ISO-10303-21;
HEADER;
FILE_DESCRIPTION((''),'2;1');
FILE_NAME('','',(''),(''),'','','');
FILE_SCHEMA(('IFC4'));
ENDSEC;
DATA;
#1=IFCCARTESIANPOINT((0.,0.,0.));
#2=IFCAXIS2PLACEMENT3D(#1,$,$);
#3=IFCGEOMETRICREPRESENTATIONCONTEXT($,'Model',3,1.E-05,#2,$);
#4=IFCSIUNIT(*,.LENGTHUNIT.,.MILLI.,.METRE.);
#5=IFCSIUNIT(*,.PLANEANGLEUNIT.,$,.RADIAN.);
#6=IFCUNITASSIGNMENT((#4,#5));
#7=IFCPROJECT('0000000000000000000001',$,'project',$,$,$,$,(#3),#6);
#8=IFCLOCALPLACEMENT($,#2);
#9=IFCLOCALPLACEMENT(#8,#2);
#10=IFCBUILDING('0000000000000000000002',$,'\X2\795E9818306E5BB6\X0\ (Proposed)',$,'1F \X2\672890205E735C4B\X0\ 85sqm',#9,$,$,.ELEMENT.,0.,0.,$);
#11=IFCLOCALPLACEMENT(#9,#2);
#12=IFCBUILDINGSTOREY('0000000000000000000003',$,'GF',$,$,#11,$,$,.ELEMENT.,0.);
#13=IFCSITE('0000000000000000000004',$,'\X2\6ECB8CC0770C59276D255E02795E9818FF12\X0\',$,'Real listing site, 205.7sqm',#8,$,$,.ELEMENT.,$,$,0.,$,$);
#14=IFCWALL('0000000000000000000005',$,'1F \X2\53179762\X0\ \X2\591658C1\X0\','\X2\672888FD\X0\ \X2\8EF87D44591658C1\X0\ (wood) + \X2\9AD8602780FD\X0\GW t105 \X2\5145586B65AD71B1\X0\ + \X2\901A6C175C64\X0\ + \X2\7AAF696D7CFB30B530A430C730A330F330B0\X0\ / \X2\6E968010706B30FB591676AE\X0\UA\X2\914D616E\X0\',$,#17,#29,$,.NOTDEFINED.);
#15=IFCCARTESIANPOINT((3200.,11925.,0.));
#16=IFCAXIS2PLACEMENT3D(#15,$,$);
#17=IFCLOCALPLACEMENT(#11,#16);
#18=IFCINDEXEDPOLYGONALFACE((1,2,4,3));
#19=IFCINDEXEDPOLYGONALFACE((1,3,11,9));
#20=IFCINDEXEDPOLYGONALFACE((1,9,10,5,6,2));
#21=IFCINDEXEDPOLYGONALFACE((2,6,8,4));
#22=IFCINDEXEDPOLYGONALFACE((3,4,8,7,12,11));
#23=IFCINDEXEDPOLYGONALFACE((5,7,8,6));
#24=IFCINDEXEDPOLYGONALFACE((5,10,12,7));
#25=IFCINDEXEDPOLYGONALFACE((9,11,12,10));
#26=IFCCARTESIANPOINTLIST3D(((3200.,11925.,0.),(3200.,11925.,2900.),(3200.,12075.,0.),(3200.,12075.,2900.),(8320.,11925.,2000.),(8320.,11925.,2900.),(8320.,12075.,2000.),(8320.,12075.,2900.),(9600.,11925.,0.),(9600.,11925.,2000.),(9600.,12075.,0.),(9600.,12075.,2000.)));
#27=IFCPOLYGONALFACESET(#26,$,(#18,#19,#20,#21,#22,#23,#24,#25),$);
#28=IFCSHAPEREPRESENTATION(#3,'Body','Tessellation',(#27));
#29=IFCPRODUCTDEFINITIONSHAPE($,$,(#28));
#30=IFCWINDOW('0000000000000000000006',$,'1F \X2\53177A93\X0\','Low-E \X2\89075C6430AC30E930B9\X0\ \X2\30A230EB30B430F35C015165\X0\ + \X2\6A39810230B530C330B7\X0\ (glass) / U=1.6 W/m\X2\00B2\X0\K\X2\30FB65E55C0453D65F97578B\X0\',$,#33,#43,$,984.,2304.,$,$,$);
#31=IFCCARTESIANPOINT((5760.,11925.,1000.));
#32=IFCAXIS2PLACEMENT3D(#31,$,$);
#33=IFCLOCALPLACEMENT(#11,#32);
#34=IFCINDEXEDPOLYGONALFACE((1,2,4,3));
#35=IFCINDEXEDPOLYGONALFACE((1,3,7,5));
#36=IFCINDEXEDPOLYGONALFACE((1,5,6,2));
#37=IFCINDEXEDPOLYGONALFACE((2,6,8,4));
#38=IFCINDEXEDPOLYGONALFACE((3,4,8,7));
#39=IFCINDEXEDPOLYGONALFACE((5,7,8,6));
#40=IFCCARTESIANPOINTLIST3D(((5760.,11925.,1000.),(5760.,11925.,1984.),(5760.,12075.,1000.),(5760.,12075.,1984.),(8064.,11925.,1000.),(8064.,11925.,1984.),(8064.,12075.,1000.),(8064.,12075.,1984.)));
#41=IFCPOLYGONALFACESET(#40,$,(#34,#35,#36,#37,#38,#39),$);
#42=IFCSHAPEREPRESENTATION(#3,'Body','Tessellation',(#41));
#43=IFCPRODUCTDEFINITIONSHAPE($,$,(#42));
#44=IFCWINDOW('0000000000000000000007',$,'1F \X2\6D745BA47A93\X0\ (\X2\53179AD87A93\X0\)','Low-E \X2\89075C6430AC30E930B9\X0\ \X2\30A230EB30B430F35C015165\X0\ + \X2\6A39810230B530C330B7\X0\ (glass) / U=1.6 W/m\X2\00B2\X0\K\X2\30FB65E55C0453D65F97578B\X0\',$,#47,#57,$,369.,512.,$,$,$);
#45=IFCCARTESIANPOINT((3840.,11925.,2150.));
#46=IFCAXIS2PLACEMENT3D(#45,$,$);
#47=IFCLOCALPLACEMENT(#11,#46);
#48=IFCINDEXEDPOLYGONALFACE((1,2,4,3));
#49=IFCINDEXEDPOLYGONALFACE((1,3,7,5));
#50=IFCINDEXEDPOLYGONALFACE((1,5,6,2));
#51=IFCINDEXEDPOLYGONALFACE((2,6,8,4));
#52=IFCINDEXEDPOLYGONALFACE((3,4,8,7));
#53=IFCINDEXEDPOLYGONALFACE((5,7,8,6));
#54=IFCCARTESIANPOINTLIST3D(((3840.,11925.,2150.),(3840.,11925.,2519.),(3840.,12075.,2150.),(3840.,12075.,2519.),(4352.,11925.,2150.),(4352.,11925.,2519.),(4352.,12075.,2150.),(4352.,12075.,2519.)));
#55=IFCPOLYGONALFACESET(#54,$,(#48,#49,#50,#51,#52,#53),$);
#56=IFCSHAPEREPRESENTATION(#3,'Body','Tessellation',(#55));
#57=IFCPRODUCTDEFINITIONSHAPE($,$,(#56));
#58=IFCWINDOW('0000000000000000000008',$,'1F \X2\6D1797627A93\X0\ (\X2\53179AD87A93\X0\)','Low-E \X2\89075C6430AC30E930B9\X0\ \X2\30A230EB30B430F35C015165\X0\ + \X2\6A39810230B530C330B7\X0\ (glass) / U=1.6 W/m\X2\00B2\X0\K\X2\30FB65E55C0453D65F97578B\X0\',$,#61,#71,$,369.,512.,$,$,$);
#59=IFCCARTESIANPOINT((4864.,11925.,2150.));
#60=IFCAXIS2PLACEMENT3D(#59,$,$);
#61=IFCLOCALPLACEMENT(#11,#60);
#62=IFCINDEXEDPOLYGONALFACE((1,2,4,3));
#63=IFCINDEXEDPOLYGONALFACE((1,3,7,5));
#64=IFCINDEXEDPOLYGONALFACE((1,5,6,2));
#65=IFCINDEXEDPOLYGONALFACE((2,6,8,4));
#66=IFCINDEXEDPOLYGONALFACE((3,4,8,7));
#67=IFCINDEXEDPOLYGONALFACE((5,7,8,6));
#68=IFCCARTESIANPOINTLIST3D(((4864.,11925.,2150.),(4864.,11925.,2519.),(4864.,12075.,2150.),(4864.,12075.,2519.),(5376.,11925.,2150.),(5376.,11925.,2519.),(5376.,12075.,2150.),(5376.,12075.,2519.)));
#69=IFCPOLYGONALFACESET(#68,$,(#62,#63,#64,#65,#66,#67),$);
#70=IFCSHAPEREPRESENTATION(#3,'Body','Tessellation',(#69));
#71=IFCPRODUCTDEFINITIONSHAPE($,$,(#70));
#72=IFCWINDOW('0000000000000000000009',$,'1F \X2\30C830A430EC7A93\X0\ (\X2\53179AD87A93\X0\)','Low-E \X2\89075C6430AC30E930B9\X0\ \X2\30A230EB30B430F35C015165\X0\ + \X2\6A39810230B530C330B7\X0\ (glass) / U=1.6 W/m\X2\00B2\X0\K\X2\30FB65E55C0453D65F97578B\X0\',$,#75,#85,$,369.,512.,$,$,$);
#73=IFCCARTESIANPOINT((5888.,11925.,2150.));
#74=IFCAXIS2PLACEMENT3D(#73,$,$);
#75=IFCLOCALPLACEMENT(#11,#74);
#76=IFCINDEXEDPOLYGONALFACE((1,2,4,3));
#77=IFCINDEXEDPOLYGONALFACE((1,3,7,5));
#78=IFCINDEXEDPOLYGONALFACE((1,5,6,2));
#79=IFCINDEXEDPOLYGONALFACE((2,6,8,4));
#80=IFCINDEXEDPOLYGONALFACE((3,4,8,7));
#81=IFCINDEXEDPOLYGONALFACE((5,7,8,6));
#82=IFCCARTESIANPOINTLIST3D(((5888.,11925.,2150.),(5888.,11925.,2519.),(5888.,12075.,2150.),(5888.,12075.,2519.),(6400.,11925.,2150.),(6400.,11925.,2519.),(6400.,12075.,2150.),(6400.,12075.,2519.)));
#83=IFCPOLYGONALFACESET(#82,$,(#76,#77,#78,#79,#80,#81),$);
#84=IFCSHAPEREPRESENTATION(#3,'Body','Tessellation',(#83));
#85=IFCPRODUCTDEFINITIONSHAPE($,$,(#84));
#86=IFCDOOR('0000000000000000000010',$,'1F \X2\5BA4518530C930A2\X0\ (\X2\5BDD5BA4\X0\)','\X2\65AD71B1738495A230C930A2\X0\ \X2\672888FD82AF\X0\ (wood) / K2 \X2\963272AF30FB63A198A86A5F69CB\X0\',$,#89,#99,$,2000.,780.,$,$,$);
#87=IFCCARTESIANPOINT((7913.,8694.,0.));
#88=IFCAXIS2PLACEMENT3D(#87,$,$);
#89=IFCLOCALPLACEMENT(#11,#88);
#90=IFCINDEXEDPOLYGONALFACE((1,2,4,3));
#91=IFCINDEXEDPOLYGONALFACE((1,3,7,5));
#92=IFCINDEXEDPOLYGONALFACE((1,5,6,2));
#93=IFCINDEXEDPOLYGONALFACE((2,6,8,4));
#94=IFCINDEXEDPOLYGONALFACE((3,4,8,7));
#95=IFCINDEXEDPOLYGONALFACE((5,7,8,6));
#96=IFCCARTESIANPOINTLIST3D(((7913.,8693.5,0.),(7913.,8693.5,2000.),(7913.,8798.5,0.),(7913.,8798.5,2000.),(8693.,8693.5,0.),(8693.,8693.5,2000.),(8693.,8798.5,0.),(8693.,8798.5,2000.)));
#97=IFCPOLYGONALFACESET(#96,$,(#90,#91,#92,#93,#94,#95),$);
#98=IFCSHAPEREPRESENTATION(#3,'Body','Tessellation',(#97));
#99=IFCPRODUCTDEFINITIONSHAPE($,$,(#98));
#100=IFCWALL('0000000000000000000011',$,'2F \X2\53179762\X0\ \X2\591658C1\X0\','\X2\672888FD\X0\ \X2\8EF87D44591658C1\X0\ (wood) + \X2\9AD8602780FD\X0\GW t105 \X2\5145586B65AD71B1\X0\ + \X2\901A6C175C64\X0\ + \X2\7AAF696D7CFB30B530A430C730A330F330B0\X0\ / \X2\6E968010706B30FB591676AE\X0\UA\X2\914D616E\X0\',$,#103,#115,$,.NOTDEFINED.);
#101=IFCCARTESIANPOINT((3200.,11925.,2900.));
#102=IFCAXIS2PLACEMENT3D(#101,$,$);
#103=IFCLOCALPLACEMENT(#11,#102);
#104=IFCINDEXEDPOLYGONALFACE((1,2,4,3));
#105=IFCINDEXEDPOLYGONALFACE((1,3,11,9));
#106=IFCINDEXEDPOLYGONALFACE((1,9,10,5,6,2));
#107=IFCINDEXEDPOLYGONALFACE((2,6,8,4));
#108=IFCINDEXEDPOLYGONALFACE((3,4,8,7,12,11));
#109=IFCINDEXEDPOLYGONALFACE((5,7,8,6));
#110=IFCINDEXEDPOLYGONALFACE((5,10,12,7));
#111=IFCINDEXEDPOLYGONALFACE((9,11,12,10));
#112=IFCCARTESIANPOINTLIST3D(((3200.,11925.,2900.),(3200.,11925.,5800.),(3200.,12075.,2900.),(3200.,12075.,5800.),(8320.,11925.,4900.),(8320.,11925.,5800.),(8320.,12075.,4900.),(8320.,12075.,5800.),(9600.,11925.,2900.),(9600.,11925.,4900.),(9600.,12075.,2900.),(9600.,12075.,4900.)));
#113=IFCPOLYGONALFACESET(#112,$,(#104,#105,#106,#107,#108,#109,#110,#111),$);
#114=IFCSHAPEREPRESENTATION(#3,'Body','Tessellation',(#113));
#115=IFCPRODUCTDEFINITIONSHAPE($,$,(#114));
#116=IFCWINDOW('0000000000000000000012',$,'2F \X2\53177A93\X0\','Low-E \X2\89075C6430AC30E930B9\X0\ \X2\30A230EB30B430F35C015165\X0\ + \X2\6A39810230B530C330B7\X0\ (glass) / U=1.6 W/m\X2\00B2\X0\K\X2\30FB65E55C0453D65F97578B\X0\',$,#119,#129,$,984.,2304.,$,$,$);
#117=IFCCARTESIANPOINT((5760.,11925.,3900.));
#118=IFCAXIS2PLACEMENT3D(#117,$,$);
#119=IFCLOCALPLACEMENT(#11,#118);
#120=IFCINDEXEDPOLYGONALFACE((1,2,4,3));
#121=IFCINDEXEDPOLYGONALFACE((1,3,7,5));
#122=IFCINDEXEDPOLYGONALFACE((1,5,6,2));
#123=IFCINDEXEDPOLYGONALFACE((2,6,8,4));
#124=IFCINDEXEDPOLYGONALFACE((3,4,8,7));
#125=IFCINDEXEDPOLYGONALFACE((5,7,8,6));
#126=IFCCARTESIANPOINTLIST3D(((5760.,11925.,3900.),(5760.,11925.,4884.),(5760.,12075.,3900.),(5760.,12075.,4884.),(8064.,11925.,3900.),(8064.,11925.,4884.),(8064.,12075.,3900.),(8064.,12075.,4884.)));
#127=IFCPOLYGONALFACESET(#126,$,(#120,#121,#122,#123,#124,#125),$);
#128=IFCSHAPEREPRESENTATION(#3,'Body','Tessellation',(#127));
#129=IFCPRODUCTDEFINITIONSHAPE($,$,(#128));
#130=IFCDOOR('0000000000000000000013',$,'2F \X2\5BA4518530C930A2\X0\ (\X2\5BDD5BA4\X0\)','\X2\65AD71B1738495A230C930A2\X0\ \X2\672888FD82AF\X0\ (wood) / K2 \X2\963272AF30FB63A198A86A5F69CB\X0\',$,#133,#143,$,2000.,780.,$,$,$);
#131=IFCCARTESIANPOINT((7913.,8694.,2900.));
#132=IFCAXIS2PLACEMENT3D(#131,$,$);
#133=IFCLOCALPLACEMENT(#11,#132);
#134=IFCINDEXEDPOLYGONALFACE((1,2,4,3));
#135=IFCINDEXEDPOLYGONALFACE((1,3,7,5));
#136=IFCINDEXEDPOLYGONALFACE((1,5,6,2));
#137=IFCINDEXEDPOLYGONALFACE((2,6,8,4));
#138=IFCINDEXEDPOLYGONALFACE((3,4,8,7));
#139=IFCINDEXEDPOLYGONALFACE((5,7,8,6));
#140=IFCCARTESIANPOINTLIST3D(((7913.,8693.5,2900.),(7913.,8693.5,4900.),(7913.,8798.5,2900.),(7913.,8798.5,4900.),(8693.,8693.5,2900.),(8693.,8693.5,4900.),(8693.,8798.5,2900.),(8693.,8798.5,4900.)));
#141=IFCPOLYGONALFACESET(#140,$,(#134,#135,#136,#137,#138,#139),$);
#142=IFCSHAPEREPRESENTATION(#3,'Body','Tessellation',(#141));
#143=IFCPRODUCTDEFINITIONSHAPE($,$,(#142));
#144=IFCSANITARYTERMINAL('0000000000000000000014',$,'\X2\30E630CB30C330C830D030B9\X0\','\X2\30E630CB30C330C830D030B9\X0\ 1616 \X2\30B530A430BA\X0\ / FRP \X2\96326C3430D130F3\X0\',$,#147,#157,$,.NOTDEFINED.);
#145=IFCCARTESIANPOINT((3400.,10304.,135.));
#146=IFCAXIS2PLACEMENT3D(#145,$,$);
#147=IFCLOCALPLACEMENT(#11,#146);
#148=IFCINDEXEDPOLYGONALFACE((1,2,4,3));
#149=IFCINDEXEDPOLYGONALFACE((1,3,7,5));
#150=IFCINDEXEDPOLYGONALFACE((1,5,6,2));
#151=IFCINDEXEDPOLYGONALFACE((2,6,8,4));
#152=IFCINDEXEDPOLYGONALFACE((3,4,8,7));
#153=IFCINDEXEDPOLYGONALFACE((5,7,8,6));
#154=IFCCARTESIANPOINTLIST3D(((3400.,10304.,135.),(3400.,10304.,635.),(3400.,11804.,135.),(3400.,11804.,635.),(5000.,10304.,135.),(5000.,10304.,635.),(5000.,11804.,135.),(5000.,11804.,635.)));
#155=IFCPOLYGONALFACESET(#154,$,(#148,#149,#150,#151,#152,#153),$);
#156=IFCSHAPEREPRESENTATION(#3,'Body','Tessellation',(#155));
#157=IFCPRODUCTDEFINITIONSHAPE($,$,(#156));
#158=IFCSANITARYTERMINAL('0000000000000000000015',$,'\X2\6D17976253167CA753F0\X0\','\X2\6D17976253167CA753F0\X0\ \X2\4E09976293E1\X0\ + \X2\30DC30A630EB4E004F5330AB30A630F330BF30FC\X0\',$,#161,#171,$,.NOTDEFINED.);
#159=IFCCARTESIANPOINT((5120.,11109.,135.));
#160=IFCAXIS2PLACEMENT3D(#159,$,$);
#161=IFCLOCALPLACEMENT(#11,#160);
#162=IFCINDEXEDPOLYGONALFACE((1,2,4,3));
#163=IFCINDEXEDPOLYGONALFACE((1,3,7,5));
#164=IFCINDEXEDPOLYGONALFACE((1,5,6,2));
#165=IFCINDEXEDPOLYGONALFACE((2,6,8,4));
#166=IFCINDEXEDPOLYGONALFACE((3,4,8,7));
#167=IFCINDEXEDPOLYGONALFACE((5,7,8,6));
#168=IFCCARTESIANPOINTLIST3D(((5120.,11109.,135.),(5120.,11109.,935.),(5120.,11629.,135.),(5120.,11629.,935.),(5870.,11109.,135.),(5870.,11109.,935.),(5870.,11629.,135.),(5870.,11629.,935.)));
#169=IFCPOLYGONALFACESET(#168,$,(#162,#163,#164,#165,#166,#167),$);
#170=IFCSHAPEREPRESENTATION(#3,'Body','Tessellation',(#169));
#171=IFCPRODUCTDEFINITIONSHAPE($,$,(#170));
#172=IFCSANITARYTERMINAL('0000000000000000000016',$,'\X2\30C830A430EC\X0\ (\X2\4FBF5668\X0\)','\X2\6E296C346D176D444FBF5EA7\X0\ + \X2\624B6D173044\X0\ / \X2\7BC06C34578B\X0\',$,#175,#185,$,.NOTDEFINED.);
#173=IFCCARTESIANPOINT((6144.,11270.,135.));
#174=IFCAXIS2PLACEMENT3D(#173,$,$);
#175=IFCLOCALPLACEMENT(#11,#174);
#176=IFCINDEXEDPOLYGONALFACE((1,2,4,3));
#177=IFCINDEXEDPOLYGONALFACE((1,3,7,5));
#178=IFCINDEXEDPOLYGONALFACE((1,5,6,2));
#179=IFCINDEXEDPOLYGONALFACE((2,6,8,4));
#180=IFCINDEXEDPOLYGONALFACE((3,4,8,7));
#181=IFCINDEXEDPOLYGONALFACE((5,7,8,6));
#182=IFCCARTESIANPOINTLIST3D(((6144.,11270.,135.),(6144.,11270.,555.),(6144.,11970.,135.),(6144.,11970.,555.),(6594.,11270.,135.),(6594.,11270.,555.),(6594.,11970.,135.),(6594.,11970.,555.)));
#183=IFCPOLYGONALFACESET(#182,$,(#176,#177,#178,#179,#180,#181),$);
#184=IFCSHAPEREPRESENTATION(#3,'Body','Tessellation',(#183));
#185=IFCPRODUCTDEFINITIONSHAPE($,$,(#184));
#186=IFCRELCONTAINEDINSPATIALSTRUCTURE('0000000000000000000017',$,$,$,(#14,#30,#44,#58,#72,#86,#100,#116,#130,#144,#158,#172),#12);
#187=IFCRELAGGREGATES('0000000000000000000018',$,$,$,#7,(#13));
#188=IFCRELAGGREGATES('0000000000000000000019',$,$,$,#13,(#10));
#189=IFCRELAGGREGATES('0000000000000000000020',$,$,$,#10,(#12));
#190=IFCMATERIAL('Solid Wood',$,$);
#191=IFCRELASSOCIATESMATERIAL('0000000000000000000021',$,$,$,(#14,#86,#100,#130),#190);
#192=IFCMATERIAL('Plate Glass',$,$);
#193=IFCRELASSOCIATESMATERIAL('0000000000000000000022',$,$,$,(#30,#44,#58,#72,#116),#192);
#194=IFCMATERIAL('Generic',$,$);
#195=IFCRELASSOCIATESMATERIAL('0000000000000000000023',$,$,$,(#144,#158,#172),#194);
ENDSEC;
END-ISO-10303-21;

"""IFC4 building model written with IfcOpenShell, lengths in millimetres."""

from ifc_helpers import new_model, si_unit, frame, frame_2d, origin, place, context, project, spatial, rectangle, extrude, material, element, fill, save


model = new_model("IFC4")

# Units and contexts
model_context = context("Model", 3, precision=1e-05, world=origin())
ifc_project = project(units=[si_unit("LENGTHUNIT", "METRE", prefix="MILLI"), si_unit("PLANEANGLEUNIT", "RADIAN")], contexts=[model_context])

# Site, building, storey
site_placement = place(None, origin())
site = spatial("IfcSite", under=ifc_project, at=site_placement, Name="滋賀県大津市神領２", ObjectType="Real listing site, 205.7sqm", CompositionType="ELEMENT", RefElevation=0.0)
building_placement = place(site_placement, origin())
building = spatial("IfcBuilding", under=site, at=building_placement, Name="神領の家 (Proposed)", ObjectType="1F 木造平屋 85sqm", CompositionType="ELEMENT", ElevationOfRefHeight=0.0, ElevationOfTerrain=0.0)
storey_placement = place(building_placement, origin())
storey = spatial("IfcBuildingStorey", under=building, at=storey_placement, Name="GF", CompositionType="ELEMENT", Elevation=0.0)

# Wall, openings, windows
ifc_material_1 = material(Name="Solid Wood")
wall_1_placement = place(storey_placement, frame((3200.0, 11925.0, 0.0)))
wall_1 = element("IfcWall", 1, at=wall_1_placement, inside=storey, material=ifc_material_1, Name="1F 北面 外壁", Description="木製 軸組外壁 (wood) + 高性能GW t105 充填断熱 + 通気層 + 窯業系サイディング / 準耐火・外皮UA配慮", PredefinedType="NOTDEFINED", context=model_context, shape_type="SweptSolid", body=[
    extrude(rectangle(XDim=6400.0, YDim=150.0, at=frame_2d((3200.0, 75.0))), frame((3200.0, 11925.0, 0.0)), (0.0, 0.0, 1.0), 2900.0),
])
opening_1_placement = place(storey_placement, frame((5760.0, 11925.0, 1000.0)))
opening_1 = element("IfcOpeningElement", 2, at=opening_1_placement, cuts=wall_1, PredefinedType="NOTDEFINED", context=model_context, shape_type="SweptSolid", body=[
    extrude(rectangle(XDim=2304.0, YDim=150.0, at=frame_2d((1152.0, 75.0))), frame((5760.0, 11925.0, 1000.0)), (0.0, 0.0, 1.0), 984.0),
])
opening_2_placement = place(storey_placement, frame((3840.0, 11925.0, 2150.0)))
opening_2 = element("IfcOpeningElement", 3, at=opening_2_placement, cuts=wall_1, PredefinedType="NOTDEFINED", context=model_context, shape_type="SweptSolid", body=[
    extrude(rectangle(XDim=512.0, YDim=150.0, at=frame_2d((256.0, 75.0))), frame((3840.0, 11925.0, 2150.0)), (0.0, 0.0, 1.0), 369.0),
])
opening_3_placement = place(storey_placement, frame((4864.0, 11925.0, 2150.0)))
opening_3 = element("IfcOpeningElement", 4, at=opening_3_placement, cuts=wall_1, PredefinedType="NOTDEFINED", context=model_context, shape_type="SweptSolid", body=[
    extrude(rectangle(XDim=512.0, YDim=150.0, at=frame_2d((256.0, 75.0))), frame((4864.0, 11925.0, 2150.0)), (0.0, 0.0, 1.0), 369.0),
])
opening_4_placement = place(storey_placement, frame((5888.0, 11925.0, 2150.0)))
opening_4 = element("IfcOpeningElement", 5, at=opening_4_placement, cuts=wall_1, PredefinedType="NOTDEFINED", context=model_context, shape_type="SweptSolid", body=[
    extrude(rectangle(XDim=512.0, YDim=150.0, at=frame_2d((256.0, 75.0))), frame((5888.0, 11925.0, 2150.0)), (0.0, 0.0, 1.0), 369.0),
])
ifc_material_2 = material(Name="Plate Glass")
window_1_placement = place(storey_placement, frame((5760.0, 11925.0, 1000.0)))
window_1 = element("IfcWindow", 6, at=window_1_placement, inside=storey, material=ifc_material_2, Name="1F 北窓", Description="Low-E 複層ガラス アルゴン封入 + 樹脂サッシ (glass) / U=1.6 W/m²K・日射取得型", OverallHeight=984.0, OverallWidth=2304.0, context=model_context, shape_type="SweptSolid", body=[
    extrude(rectangle(XDim=2304.0, YDim=150.0, at=frame_2d((1152.0, 75.0))), frame((5760.0, 11925.0, 1000.0)), (0.0, 0.0, 1.0), 984.0),
])
fill(opening_1, window_1)
window_2_placement = place(storey_placement, frame((3840.0, 11925.0, 2150.0)))
window_2 = element("IfcWindow", 7, at=window_2_placement, inside=storey, material=ifc_material_2, Name="1F 浴室窓 (北高窓)", Description="Low-E 複層ガラス アルゴン封入 + 樹脂サッシ (glass) / U=1.6 W/m²K・日射取得型", OverallHeight=369.0, OverallWidth=512.0, context=model_context, shape_type="SweptSolid", body=[
    extrude(rectangle(XDim=512.0, YDim=150.0, at=frame_2d((256.0, 75.0))), frame((3840.0, 11925.0, 2150.0)), (0.0, 0.0, 1.0), 369.0),
])
fill(opening_2, window_2)
window_3_placement = place(storey_placement, frame((4864.0, 11925.0, 2150.0)))
window_3 = element("IfcWindow", 8, at=window_3_placement, inside=storey, material=ifc_material_2, Name="1F 洗面窓 (北高窓)", Description="Low-E 複層ガラス アルゴン封入 + 樹脂サッシ (glass) / U=1.6 W/m²K・日射取得型", OverallHeight=369.0, OverallWidth=512.0, context=model_context, shape_type="SweptSolid", body=[
    extrude(rectangle(XDim=512.0, YDim=150.0, at=frame_2d((256.0, 75.0))), frame((4864.0, 11925.0, 2150.0)), (0.0, 0.0, 1.0), 369.0),
])
fill(opening_3, window_3)
window_4_placement = place(storey_placement, frame((5888.0, 11925.0, 2150.0)))
window_4 = element("IfcWindow", 9, at=window_4_placement, inside=storey, material=ifc_material_2, Name="1F トイレ窓 (北高窓)", Description="Low-E 複層ガラス アルゴン封入 + 樹脂サッシ (glass) / U=1.6 W/m²K・日射取得型", OverallHeight=369.0, OverallWidth=512.0, context=model_context, shape_type="SweptSolid", body=[
    extrude(rectangle(XDim=512.0, YDim=150.0, at=frame_2d((256.0, 75.0))), frame((5888.0, 11925.0, 2150.0)), (0.0, 0.0, 1.0), 369.0),
])
fill(opening_4, window_4)

# Door
door_1_placement = place(storey_placement, frame((7913.0, 8694.0, 0.0)))
element("IfcDoor", 10, at=door_1_placement, inside=storey, material=ifc_material_1, Name="1F 室内ドア (寝室)", Description="断熱玄関ドア 木製芯 (wood) / K2 防犯・採風機構", OverallHeight=2000.0, OverallWidth=780.0, context=model_context, shape_type="SweptSolid", body=[
    extrude(rectangle(XDim=780.0, YDim=105.0, at=frame_2d((390.0, 52.0))), frame((7913.0, 8694.0, 0.0)), (0.0, 0.0, 1.0), 2000.0),
])

# Wall, opening, window
wall_2_placement = place(storey_placement, frame((3200.0, 11925.0, 2900.0)))
wall_2 = element("IfcWall", 11, at=wall_2_placement, inside=storey, material=ifc_material_1, Name="2F 北面 外壁", Description="木製 軸組外壁 (wood) + 高性能GW t105 充填断熱 + 通気層 + 窯業系サイディング / 準耐火・外皮UA配慮", PredefinedType="NOTDEFINED", context=model_context, shape_type="SweptSolid", body=[
    extrude(rectangle(XDim=6400.0, YDim=150.0, at=frame_2d((3200.0, 75.0))), frame((3200.0, 11925.0, 2900.0)), (0.0, 0.0, 1.0), 2900.0),
])
opening_5_placement = place(storey_placement, frame((5760.0, 11925.0, 3900.0)))
opening_5 = element("IfcOpeningElement", 12, at=opening_5_placement, cuts=wall_2, PredefinedType="NOTDEFINED", context=model_context, shape_type="SweptSolid", body=[
    extrude(rectangle(XDim=2304.0, YDim=150.0, at=frame_2d((1152.0, 75.0))), frame((5760.0, 11925.0, 3900.0)), (0.0, 0.0, 1.0), 984.0),
])
window_5_placement = place(storey_placement, frame((5760.0, 11925.0, 3900.0)))
window_5 = element("IfcWindow", 13, at=window_5_placement, inside=storey, material=ifc_material_2, Name="2F 北窓", Description="Low-E 複層ガラス アルゴン封入 + 樹脂サッシ (glass) / U=1.6 W/m²K・日射取得型", OverallHeight=984.0, OverallWidth=2304.0, context=model_context, shape_type="SweptSolid", body=[
    extrude(rectangle(XDim=2304.0, YDim=150.0, at=frame_2d((1152.0, 75.0))), frame((5760.0, 11925.0, 3900.0)), (0.0, 0.0, 1.0), 984.0),
])
fill(opening_5, window_5)

# Door
door_2_placement = place(storey_placement, frame((7913.0, 8694.0, 2900.0)))
element("IfcDoor", 14, at=door_2_placement, inside=storey, material=ifc_material_1, Name="2F 室内ドア (寝室)", Description="断熱玄関ドア 木製芯 (wood) / K2 防犯・採風機構", OverallHeight=2000.0, OverallWidth=780.0, context=model_context, shape_type="SweptSolid", body=[
    extrude(rectangle(XDim=780.0, YDim=105.0, at=frame_2d((390.0, 52.0))), frame((7913.0, 8694.0, 2900.0)), (0.0, 0.0, 1.0), 2000.0),
])

# Sanitary terminals
ifc_material_3 = material(Name="Generic")
sanitary_terminal_1_placement = place(storey_placement, frame((3400.0, 10304.0, 135.0)))
element("IfcSanitaryTerminal", 15, at=sanitary_terminal_1_placement, inside=storey, material=ifc_material_3, Name="ユニットバス", Description="ユニットバス 1616 サイズ / FRP 防水パン", PredefinedType="NOTDEFINED", context=model_context, shape_type="SweptSolid", body=[
    extrude(rectangle(XDim=1600.0, YDim=1500.0, at=frame_2d((800.0, 750.0))), frame((3400.0, 10304.0, 135.0)), (0.0, 0.0, 1.0), 500.0),
])
sanitary_terminal_2_placement = place(storey_placement, frame((5120.0, 11109.0, 135.0)))
element("IfcSanitaryTerminal", 16, at=sanitary_terminal_2_placement, inside=storey, material=ifc_material_3, Name="洗面化粧台", Description="洗面化粧台 三面鏡 + ボウル一体カウンター", PredefinedType="NOTDEFINED", context=model_context, shape_type="SweptSolid", body=[
    extrude(rectangle(XDim=750.0, YDim=520.0, at=frame_2d((375.0, 260.0))), frame((5120.0, 11109.0, 135.0)), (0.0, 0.0, 1.0), 800.0),
])
sanitary_terminal_3_placement = place(storey_placement, frame((6144.0, 11270.0, 135.0)))
element("IfcSanitaryTerminal", 17, at=sanitary_terminal_3_placement, inside=storey, material=ifc_material_3, Name="トイレ (便器)", Description="温水洗浄便座 + 手洗い / 節水型", PredefinedType="NOTDEFINED", context=model_context, shape_type="SweptSolid", body=[
    extrude(rectangle(XDim=450.0, YDim=700.0, at=frame_2d((225.0, 350.0))), frame((6144.0, 11270.0, 135.0)), (0.0, 0.0, 1.0), 420.0),
])

save(model, "model.ifc")
